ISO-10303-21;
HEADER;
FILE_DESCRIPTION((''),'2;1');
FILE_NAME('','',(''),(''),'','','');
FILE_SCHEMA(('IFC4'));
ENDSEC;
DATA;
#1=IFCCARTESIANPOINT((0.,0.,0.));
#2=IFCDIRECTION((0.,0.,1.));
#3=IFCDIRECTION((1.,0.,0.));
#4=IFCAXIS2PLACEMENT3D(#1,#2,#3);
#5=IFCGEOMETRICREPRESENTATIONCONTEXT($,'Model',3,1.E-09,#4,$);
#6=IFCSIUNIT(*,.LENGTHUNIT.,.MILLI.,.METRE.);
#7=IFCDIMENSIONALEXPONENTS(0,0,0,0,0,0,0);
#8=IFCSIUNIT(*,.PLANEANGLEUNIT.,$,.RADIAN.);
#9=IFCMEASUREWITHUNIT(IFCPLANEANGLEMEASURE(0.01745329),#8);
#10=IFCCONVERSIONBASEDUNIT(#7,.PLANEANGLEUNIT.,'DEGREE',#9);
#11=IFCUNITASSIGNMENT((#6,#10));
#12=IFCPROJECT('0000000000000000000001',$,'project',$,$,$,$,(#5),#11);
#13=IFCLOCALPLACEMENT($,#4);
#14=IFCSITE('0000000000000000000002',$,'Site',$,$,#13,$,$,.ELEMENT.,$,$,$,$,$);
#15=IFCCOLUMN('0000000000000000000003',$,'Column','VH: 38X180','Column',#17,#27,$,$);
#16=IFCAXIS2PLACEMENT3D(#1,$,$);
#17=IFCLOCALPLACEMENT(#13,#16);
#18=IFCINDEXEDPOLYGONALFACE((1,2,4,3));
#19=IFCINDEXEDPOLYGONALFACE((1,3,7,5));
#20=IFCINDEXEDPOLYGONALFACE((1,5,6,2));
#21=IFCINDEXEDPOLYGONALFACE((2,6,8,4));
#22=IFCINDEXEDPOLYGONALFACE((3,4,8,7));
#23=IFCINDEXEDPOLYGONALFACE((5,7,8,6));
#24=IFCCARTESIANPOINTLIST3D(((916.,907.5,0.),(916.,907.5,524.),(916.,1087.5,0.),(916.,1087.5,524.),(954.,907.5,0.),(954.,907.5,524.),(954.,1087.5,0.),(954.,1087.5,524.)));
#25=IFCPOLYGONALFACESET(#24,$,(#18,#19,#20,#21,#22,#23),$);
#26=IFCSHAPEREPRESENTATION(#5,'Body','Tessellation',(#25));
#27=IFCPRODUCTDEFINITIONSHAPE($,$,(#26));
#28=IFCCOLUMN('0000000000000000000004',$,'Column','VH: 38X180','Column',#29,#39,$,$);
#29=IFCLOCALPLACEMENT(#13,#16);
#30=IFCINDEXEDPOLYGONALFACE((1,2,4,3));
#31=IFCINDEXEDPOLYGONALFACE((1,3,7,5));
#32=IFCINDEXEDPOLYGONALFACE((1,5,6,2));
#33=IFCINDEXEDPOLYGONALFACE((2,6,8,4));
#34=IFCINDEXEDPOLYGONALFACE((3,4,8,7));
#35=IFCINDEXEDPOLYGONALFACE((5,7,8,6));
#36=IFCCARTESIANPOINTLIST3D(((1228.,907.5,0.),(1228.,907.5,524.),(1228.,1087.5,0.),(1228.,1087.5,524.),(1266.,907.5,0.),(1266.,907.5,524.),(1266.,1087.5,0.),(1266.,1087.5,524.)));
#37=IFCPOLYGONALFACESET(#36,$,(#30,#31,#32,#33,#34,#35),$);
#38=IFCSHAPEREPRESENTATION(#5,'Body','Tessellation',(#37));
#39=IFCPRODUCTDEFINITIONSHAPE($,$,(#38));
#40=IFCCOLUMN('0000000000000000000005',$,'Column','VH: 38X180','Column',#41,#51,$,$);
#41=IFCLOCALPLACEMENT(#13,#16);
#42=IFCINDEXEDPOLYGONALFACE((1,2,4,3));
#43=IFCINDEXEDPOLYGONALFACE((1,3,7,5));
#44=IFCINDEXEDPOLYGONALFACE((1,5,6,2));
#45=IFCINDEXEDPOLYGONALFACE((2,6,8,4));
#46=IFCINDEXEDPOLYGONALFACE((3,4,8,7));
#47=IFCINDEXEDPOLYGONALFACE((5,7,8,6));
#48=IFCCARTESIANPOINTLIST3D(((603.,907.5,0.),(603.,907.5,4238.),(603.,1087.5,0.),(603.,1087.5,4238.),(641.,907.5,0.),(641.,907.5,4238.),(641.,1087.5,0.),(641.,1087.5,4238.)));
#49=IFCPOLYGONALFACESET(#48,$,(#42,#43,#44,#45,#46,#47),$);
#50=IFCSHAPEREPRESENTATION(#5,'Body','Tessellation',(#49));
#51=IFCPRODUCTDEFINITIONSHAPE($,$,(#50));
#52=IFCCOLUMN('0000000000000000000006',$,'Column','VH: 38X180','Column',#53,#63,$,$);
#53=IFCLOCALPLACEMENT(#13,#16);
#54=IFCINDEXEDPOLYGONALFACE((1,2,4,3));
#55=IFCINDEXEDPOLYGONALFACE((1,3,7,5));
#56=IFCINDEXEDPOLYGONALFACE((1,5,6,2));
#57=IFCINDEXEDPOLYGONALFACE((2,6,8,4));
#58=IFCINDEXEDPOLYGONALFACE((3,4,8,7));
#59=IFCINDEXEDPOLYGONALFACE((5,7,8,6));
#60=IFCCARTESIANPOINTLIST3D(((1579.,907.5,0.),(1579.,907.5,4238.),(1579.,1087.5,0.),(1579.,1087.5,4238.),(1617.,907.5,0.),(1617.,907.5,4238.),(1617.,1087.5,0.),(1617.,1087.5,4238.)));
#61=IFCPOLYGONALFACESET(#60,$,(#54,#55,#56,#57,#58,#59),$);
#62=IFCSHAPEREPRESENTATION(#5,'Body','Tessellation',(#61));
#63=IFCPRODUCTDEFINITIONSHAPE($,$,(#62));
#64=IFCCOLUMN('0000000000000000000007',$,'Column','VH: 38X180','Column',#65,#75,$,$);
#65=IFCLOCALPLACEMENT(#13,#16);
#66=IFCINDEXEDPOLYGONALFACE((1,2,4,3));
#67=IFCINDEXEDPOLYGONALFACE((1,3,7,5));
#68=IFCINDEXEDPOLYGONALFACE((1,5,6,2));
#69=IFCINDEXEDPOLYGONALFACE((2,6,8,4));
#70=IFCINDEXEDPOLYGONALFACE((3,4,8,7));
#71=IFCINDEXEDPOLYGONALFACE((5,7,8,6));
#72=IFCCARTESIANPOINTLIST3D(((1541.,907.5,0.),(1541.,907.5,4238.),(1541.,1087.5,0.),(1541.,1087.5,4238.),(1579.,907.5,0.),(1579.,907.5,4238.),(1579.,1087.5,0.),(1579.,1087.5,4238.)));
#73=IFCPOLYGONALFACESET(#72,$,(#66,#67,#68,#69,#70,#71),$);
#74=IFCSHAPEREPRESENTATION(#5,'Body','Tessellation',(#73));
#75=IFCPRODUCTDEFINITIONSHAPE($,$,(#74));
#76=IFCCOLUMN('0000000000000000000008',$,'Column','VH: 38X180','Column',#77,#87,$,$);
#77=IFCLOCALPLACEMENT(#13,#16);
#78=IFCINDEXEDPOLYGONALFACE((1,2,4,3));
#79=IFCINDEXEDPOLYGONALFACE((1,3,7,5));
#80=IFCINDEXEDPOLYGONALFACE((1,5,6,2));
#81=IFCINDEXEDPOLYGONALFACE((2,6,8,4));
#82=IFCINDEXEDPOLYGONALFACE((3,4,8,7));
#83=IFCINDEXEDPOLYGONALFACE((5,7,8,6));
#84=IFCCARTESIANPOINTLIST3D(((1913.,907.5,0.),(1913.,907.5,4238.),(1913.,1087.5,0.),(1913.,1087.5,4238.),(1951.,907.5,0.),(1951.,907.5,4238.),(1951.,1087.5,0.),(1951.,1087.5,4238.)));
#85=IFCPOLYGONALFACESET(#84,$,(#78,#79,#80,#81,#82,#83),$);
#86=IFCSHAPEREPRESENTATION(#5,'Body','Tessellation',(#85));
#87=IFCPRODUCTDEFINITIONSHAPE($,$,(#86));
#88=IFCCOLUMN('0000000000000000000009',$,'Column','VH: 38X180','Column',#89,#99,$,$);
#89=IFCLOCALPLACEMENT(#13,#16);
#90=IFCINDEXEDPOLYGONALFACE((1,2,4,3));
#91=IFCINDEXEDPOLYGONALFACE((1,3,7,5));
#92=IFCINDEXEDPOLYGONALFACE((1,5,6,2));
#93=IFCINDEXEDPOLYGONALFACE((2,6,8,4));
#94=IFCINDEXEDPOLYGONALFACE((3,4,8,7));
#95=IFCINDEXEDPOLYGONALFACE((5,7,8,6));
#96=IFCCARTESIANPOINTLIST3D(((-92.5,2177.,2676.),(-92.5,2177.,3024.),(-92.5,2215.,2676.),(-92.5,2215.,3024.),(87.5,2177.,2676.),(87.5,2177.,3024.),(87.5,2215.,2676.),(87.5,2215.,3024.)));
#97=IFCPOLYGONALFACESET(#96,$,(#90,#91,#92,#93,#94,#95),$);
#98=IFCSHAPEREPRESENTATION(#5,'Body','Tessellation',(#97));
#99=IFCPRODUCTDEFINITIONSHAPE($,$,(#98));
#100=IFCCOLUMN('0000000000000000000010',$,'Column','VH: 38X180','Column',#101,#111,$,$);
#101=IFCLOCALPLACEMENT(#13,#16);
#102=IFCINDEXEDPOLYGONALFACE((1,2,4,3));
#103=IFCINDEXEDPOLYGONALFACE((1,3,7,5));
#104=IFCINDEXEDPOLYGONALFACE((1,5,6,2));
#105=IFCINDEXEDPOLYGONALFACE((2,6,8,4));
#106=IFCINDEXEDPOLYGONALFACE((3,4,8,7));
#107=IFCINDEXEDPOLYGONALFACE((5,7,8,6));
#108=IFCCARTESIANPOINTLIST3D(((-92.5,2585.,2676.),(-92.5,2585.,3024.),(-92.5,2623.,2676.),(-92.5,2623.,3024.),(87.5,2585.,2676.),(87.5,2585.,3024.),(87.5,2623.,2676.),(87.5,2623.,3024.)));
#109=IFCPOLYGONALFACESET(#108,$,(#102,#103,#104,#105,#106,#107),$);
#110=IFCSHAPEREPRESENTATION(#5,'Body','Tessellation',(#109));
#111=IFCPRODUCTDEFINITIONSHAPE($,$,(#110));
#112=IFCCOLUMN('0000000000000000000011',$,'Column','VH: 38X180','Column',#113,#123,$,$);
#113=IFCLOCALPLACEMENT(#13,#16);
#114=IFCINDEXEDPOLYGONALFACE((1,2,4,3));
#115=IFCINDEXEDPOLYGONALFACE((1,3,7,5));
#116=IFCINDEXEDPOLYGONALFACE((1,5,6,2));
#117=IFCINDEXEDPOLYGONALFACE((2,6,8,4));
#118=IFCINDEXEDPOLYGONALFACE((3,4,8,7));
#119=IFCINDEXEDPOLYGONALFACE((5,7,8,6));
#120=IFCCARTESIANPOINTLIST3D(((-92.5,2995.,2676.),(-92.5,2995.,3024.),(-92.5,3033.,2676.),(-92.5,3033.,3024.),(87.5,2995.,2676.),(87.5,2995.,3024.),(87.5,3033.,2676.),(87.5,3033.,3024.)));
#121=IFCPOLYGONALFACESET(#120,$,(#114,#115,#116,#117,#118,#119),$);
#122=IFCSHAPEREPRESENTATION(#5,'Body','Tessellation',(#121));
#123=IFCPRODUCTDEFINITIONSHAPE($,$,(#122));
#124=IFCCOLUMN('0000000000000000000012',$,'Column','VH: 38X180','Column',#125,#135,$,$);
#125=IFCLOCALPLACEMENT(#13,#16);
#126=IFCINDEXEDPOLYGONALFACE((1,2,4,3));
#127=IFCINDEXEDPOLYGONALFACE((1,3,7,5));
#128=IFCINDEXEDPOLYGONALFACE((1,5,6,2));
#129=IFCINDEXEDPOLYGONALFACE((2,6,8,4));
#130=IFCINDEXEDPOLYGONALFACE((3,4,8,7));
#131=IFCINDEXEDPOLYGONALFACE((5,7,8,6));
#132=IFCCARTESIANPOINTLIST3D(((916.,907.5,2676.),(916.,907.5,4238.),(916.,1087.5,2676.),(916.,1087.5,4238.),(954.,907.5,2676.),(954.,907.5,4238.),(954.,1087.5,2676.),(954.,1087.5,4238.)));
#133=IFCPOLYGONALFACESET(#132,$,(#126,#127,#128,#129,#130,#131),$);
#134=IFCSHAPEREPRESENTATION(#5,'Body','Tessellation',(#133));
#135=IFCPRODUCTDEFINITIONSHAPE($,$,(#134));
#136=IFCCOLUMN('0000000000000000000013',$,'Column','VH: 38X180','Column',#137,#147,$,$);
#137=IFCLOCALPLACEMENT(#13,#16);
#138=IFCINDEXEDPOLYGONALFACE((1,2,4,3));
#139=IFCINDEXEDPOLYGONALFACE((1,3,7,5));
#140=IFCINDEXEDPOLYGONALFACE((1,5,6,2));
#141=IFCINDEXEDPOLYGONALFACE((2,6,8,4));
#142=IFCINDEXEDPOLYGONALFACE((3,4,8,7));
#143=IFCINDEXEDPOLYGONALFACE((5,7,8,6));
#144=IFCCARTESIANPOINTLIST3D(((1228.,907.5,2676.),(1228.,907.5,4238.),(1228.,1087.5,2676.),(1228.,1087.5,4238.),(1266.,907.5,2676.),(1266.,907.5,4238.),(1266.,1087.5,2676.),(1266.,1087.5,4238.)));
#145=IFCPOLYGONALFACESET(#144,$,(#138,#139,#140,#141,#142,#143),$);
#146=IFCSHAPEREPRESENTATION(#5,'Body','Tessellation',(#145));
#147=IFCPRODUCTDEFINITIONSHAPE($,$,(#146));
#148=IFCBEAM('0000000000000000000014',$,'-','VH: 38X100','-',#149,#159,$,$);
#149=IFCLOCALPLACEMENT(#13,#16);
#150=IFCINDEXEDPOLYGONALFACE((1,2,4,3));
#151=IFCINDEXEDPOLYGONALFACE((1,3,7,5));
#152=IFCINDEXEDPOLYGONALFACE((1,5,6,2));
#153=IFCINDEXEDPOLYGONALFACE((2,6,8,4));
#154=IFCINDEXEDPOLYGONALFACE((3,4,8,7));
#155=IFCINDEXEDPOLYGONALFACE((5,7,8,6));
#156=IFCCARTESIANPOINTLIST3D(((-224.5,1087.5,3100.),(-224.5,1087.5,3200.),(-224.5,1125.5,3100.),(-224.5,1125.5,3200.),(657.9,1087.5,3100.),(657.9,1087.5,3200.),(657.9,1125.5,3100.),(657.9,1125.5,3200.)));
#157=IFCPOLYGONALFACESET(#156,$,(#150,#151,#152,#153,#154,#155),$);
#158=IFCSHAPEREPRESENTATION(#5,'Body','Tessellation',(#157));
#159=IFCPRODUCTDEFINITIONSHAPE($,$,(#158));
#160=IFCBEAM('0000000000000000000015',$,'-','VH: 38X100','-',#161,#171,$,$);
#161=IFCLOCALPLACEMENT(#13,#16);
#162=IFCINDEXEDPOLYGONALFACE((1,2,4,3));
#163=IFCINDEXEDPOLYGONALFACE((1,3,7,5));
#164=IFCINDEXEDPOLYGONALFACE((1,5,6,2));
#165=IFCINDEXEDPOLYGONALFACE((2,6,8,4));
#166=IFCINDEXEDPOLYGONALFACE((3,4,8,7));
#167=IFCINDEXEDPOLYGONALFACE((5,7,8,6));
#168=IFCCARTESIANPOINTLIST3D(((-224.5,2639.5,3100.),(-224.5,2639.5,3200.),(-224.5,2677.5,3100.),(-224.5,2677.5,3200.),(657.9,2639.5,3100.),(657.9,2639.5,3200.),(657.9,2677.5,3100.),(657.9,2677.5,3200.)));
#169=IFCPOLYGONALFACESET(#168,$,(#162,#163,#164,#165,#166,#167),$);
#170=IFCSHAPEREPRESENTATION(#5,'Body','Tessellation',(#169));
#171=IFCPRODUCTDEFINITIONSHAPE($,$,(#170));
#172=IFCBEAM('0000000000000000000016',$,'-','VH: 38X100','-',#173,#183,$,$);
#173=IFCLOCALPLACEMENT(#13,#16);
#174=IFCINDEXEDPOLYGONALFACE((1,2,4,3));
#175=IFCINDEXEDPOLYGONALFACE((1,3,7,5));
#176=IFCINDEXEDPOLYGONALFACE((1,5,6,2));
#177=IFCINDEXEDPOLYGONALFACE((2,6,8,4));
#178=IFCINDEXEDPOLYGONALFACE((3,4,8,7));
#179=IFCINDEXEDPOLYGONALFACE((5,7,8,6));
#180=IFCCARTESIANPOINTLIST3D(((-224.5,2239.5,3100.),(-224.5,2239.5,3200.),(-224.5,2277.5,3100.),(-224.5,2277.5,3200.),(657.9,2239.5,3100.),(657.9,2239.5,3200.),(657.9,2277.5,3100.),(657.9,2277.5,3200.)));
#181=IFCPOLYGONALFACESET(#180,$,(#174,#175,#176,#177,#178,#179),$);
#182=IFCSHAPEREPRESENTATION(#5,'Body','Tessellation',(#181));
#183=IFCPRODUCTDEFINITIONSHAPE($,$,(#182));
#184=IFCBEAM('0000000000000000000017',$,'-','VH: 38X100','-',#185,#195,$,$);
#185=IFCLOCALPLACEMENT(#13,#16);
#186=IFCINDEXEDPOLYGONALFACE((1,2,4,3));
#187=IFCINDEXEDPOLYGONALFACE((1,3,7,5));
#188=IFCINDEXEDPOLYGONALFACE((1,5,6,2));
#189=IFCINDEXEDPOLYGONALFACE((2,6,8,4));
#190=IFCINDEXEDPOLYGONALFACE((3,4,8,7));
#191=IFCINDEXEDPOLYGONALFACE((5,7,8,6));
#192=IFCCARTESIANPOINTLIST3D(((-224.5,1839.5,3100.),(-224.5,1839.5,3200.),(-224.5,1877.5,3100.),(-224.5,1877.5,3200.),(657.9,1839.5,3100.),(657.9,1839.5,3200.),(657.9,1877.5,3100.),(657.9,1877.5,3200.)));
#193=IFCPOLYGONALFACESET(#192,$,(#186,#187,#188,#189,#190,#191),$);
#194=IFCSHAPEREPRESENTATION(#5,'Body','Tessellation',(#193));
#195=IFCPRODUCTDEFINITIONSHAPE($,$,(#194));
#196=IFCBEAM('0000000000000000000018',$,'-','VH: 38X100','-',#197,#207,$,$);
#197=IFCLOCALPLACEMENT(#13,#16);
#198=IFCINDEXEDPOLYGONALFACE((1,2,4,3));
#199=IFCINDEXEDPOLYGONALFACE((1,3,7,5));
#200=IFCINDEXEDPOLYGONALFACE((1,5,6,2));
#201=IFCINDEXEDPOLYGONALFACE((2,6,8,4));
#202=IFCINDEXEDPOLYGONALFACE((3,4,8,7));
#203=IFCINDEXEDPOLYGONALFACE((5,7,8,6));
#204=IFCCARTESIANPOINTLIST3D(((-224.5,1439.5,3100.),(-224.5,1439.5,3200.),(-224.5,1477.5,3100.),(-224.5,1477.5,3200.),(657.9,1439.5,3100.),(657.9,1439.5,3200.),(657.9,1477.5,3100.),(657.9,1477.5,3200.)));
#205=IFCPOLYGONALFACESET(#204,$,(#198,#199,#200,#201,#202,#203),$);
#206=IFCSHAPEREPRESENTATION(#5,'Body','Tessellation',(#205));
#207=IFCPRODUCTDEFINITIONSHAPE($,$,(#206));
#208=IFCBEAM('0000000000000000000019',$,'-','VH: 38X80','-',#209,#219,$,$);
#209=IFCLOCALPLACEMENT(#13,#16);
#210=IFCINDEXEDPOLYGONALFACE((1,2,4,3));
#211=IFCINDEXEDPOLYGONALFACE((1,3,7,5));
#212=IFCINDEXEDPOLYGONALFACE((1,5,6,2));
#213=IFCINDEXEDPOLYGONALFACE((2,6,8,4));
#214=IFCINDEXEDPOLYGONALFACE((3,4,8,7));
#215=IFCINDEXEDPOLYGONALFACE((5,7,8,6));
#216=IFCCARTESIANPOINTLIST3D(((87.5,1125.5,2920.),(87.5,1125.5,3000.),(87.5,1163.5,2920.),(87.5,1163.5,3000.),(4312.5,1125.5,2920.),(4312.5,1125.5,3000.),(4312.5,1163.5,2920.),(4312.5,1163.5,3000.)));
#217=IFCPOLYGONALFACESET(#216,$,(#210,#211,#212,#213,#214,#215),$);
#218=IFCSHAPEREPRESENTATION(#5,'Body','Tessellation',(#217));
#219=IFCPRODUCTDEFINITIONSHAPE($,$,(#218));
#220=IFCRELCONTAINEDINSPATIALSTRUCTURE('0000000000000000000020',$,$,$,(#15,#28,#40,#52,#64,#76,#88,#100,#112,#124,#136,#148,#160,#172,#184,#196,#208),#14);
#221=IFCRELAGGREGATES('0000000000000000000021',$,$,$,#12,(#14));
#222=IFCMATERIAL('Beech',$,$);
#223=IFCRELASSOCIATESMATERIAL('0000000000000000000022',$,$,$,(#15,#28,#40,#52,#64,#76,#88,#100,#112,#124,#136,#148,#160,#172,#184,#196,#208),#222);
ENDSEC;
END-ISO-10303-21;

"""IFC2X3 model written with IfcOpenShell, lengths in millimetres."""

from ifc_helpers import new_model, entity, si_unit, converted_unit, frame, origin, origin_with_axes, origin_2d, place, context, project, spatial, rectangle, extrude, material, element, save


model = new_model("IFC2X3")

# Units and contexts
model_context = context("Model", 3, precision=1e-09, world=origin_with_axes())
ifc_project = project(units=[si_unit("LENGTHUNIT", "METRE", prefix="MILLI"), converted_unit("PLANEANGLEUNIT", "DEGREE", entity("IfcPlaneAngleMeasure", 0.01745329), si_unit("PLANEANGLEUNIT", "RADIAN"), dimensions=[0, 0, 0, 0, 0, 0, 0])], contexts=[model_context])

# Site
site_placement = place(None, origin_with_axes())
site = spatial("IfcSite", under=ifc_project, at=site_placement, Name="Site", CompositionType="ELEMENT")

# Columns
ifc_material_1 = material(Name="Beech")
for number, where, z_axis, x_axis, name in (
    (1, (935.0, 997.5, 0.0), (0.0, 0.0, -1.0), (-1.0, 0.0, 0.0), "Column"),
    (2, (1247.0, 997.5, 0.0), (0.0, 0.0, -1.0), (-1.0, 0.0, 0.0), "Column"),
):
    element("IfcColumn", number, at=place(None, frame(where, z_axis=z_axis, x_axis=x_axis)), inside=site, material=ifc_material_1, Name=name, Description="VH: 38X180", ObjectType="Column", context=model_context, shape_type="SweptSolid", body=[
        extrude(rectangle(XDim=38.0, YDim=180.0, at=origin_2d()), origin(), (0.0, 0.0, -1.0), 524.0),
    ])
for number, where, z_axis, x_axis, name in (
    (3, (622.0, 997.5, 0.0), (0.0, 0.0, -1.0), (-1.0, 0.0, 0.0), "Column"),
    (4, (1598.0, 997.5, 0.0), (0.0, 0.0, -1.0), (-1.0, 0.0, 0.0), "Column"),
    (5, (1560.0, 997.5, 0.0), (0.0, 0.0, -1.0), (-1.0, 0.0, 0.0), "Column"),
    (6, (1932.0, 997.5, 0.0), (0.0, 0.0, -1.0), (-1.0, 0.0, 0.0), "Column"),
):
    element("IfcColumn", number, at=place(None, frame(where, z_axis=z_axis, x_axis=x_axis)), inside=site, material=ifc_material_1, Name=name, Description="VH: 38X180", ObjectType="Column", context=model_context, shape_type="SweptSolid", body=[
        extrude(rectangle(XDim=38.0, YDim=180.0, at=origin_2d()), origin(), (0.0, 0.0, -1.0), 4238.0),
    ])
for number, where, z_axis, x_axis, name in (
    (7, (-2.5, 2196.0, 2676.0), (0.0, 0.0, -1.0), (0.0, -1.0, 0.0), "Column"),
    (8, (-2.5, 2604.0, 2676.0), (0.0, 0.0, -1.0), (0.0, -1.0, 0.0), "Column"),
    (9, (-2.5, 3014.0, 2676.0), (0.0, 0.0, -1.0), (0.0, -1.0, 0.0), "Column"),
):
    element("IfcColumn", number, at=place(None, frame(where, z_axis=z_axis, x_axis=x_axis)), inside=site, material=ifc_material_1, Name=name, Description="VH: 38X180", ObjectType="Column", context=model_context, shape_type="SweptSolid", body=[
        extrude(rectangle(XDim=38.0, YDim=180.0, at=origin_2d()), origin(), (0.0, 0.0, -1.0), 348.0),
    ])
for number, where, z_axis, x_axis, name in (
    (10, (935.0, 997.5, 2676.0), (0.0, 0.0, -1.0), (-1.0, 0.0, 0.0), "Column"),
    (11, (1247.0, 997.5, 2676.0), (0.0, 0.0, -1.0), (-1.0, 0.0, 0.0), "Column"),
):
    element("IfcColumn", number, at=place(None, frame(where, z_axis=z_axis, x_axis=x_axis)), inside=site, material=ifc_material_1, Name=name, Description="VH: 38X180", ObjectType="Column", context=model_context, shape_type="SweptSolid", body=[
        extrude(rectangle(XDim=38.0, YDim=180.0, at=origin_2d()), origin(), (0.0, 0.0, -1.0), 1562.0),
    ])

# Beams
beam_1_placement = place(None, frame((657.9, 1106.5, 3150.0), z_axis=(1.0, -0.000018, 0.0), x_axis=(0.000018, 1.0, 0.0)))
element("IfcBeam", 12, at=beam_1_placement, inside=site, material=ifc_material_1, Name="-", Description="VH: 38X100", ObjectType="-", context=model_context, shape_type="SweptSolid", body=[
    extrude(rectangle(XDim=38.0, YDim=100.0, at=origin_2d()), origin(), (0.0, 0.0, -1.0), 882.4),
])
beam_2_placement = place(None, frame((657.9, 2658.5, 3150.0), z_axis=(1.0, -0.000018, 0.0), x_axis=(0.000018, 1.0, 0.0)))
element("IfcBeam", 13, at=beam_2_placement, inside=site, material=ifc_material_1, Name="-", Description="VH: 38X100", ObjectType="-", context=model_context, shape_type="SweptSolid", body=[
    extrude(rectangle(XDim=38.0, YDim=100.0, at=origin_2d()), origin(), (0.0, 0.0, -1.0), 882.4),
])
beam_3_placement = place(None, frame((657.9, 2258.5, 3150.0), z_axis=(1.0, -0.000018, 0.0), x_axis=(0.000018, 1.0, 0.0)))
element("IfcBeam", 14, at=beam_3_placement, inside=site, material=ifc_material_1, Name="-", Description="VH: 38X100", ObjectType="-", context=model_context, shape_type="SweptSolid", body=[
    extrude(rectangle(XDim=38.0, YDim=100.0, at=origin_2d()), origin(), (0.0, 0.0, -1.0), 882.4),
])
beam_4_placement = place(None, frame((657.9, 1858.5, 3150.0), z_axis=(1.0, -0.000018, 0.0), x_axis=(0.000018, 1.0, 0.0)))
element("IfcBeam", 15, at=beam_4_placement, inside=site, material=ifc_material_1, Name="-", Description="VH: 38X100", ObjectType="-", context=model_context, shape_type="SweptSolid", body=[
    extrude(rectangle(XDim=38.0, YDim=100.0, at=origin_2d()), origin(), (0.0, 0.0, -1.0), 882.4),
])
beam_5_placement = place(None, frame((657.9, 1458.5, 3150.0), z_axis=(1.0, -0.000018, 0.0), x_axis=(0.000018, 1.0, 0.0)))
element("IfcBeam", 16, at=beam_5_placement, inside=site, material=ifc_material_1, Name="-", Description="VH: 38X100", ObjectType="-", context=model_context, shape_type="SweptSolid", body=[
    extrude(rectangle(XDim=38.0, YDim=100.0, at=origin_2d()), origin(), (0.0, 0.0, -1.0), 882.4),
])
beam_6_placement = place(None, frame((87.5, 1144.5, 2960.0), z_axis=(-1.0, 0.0, 0.0), x_axis=(0.0, -1.0, 0.0)))
element("IfcBeam", 17, at=beam_6_placement, inside=site, material=ifc_material_1, Name="-", Description="VH: 38X80", ObjectType="-", context=model_context, shape_type="SweptSolid", body=[
    extrude(rectangle(XDim=38.0, YDim=80.0, at=origin_2d()), origin(), (0.0, 0.0, -1.0), 4225.0),
])

save(model, "model.ifc")
